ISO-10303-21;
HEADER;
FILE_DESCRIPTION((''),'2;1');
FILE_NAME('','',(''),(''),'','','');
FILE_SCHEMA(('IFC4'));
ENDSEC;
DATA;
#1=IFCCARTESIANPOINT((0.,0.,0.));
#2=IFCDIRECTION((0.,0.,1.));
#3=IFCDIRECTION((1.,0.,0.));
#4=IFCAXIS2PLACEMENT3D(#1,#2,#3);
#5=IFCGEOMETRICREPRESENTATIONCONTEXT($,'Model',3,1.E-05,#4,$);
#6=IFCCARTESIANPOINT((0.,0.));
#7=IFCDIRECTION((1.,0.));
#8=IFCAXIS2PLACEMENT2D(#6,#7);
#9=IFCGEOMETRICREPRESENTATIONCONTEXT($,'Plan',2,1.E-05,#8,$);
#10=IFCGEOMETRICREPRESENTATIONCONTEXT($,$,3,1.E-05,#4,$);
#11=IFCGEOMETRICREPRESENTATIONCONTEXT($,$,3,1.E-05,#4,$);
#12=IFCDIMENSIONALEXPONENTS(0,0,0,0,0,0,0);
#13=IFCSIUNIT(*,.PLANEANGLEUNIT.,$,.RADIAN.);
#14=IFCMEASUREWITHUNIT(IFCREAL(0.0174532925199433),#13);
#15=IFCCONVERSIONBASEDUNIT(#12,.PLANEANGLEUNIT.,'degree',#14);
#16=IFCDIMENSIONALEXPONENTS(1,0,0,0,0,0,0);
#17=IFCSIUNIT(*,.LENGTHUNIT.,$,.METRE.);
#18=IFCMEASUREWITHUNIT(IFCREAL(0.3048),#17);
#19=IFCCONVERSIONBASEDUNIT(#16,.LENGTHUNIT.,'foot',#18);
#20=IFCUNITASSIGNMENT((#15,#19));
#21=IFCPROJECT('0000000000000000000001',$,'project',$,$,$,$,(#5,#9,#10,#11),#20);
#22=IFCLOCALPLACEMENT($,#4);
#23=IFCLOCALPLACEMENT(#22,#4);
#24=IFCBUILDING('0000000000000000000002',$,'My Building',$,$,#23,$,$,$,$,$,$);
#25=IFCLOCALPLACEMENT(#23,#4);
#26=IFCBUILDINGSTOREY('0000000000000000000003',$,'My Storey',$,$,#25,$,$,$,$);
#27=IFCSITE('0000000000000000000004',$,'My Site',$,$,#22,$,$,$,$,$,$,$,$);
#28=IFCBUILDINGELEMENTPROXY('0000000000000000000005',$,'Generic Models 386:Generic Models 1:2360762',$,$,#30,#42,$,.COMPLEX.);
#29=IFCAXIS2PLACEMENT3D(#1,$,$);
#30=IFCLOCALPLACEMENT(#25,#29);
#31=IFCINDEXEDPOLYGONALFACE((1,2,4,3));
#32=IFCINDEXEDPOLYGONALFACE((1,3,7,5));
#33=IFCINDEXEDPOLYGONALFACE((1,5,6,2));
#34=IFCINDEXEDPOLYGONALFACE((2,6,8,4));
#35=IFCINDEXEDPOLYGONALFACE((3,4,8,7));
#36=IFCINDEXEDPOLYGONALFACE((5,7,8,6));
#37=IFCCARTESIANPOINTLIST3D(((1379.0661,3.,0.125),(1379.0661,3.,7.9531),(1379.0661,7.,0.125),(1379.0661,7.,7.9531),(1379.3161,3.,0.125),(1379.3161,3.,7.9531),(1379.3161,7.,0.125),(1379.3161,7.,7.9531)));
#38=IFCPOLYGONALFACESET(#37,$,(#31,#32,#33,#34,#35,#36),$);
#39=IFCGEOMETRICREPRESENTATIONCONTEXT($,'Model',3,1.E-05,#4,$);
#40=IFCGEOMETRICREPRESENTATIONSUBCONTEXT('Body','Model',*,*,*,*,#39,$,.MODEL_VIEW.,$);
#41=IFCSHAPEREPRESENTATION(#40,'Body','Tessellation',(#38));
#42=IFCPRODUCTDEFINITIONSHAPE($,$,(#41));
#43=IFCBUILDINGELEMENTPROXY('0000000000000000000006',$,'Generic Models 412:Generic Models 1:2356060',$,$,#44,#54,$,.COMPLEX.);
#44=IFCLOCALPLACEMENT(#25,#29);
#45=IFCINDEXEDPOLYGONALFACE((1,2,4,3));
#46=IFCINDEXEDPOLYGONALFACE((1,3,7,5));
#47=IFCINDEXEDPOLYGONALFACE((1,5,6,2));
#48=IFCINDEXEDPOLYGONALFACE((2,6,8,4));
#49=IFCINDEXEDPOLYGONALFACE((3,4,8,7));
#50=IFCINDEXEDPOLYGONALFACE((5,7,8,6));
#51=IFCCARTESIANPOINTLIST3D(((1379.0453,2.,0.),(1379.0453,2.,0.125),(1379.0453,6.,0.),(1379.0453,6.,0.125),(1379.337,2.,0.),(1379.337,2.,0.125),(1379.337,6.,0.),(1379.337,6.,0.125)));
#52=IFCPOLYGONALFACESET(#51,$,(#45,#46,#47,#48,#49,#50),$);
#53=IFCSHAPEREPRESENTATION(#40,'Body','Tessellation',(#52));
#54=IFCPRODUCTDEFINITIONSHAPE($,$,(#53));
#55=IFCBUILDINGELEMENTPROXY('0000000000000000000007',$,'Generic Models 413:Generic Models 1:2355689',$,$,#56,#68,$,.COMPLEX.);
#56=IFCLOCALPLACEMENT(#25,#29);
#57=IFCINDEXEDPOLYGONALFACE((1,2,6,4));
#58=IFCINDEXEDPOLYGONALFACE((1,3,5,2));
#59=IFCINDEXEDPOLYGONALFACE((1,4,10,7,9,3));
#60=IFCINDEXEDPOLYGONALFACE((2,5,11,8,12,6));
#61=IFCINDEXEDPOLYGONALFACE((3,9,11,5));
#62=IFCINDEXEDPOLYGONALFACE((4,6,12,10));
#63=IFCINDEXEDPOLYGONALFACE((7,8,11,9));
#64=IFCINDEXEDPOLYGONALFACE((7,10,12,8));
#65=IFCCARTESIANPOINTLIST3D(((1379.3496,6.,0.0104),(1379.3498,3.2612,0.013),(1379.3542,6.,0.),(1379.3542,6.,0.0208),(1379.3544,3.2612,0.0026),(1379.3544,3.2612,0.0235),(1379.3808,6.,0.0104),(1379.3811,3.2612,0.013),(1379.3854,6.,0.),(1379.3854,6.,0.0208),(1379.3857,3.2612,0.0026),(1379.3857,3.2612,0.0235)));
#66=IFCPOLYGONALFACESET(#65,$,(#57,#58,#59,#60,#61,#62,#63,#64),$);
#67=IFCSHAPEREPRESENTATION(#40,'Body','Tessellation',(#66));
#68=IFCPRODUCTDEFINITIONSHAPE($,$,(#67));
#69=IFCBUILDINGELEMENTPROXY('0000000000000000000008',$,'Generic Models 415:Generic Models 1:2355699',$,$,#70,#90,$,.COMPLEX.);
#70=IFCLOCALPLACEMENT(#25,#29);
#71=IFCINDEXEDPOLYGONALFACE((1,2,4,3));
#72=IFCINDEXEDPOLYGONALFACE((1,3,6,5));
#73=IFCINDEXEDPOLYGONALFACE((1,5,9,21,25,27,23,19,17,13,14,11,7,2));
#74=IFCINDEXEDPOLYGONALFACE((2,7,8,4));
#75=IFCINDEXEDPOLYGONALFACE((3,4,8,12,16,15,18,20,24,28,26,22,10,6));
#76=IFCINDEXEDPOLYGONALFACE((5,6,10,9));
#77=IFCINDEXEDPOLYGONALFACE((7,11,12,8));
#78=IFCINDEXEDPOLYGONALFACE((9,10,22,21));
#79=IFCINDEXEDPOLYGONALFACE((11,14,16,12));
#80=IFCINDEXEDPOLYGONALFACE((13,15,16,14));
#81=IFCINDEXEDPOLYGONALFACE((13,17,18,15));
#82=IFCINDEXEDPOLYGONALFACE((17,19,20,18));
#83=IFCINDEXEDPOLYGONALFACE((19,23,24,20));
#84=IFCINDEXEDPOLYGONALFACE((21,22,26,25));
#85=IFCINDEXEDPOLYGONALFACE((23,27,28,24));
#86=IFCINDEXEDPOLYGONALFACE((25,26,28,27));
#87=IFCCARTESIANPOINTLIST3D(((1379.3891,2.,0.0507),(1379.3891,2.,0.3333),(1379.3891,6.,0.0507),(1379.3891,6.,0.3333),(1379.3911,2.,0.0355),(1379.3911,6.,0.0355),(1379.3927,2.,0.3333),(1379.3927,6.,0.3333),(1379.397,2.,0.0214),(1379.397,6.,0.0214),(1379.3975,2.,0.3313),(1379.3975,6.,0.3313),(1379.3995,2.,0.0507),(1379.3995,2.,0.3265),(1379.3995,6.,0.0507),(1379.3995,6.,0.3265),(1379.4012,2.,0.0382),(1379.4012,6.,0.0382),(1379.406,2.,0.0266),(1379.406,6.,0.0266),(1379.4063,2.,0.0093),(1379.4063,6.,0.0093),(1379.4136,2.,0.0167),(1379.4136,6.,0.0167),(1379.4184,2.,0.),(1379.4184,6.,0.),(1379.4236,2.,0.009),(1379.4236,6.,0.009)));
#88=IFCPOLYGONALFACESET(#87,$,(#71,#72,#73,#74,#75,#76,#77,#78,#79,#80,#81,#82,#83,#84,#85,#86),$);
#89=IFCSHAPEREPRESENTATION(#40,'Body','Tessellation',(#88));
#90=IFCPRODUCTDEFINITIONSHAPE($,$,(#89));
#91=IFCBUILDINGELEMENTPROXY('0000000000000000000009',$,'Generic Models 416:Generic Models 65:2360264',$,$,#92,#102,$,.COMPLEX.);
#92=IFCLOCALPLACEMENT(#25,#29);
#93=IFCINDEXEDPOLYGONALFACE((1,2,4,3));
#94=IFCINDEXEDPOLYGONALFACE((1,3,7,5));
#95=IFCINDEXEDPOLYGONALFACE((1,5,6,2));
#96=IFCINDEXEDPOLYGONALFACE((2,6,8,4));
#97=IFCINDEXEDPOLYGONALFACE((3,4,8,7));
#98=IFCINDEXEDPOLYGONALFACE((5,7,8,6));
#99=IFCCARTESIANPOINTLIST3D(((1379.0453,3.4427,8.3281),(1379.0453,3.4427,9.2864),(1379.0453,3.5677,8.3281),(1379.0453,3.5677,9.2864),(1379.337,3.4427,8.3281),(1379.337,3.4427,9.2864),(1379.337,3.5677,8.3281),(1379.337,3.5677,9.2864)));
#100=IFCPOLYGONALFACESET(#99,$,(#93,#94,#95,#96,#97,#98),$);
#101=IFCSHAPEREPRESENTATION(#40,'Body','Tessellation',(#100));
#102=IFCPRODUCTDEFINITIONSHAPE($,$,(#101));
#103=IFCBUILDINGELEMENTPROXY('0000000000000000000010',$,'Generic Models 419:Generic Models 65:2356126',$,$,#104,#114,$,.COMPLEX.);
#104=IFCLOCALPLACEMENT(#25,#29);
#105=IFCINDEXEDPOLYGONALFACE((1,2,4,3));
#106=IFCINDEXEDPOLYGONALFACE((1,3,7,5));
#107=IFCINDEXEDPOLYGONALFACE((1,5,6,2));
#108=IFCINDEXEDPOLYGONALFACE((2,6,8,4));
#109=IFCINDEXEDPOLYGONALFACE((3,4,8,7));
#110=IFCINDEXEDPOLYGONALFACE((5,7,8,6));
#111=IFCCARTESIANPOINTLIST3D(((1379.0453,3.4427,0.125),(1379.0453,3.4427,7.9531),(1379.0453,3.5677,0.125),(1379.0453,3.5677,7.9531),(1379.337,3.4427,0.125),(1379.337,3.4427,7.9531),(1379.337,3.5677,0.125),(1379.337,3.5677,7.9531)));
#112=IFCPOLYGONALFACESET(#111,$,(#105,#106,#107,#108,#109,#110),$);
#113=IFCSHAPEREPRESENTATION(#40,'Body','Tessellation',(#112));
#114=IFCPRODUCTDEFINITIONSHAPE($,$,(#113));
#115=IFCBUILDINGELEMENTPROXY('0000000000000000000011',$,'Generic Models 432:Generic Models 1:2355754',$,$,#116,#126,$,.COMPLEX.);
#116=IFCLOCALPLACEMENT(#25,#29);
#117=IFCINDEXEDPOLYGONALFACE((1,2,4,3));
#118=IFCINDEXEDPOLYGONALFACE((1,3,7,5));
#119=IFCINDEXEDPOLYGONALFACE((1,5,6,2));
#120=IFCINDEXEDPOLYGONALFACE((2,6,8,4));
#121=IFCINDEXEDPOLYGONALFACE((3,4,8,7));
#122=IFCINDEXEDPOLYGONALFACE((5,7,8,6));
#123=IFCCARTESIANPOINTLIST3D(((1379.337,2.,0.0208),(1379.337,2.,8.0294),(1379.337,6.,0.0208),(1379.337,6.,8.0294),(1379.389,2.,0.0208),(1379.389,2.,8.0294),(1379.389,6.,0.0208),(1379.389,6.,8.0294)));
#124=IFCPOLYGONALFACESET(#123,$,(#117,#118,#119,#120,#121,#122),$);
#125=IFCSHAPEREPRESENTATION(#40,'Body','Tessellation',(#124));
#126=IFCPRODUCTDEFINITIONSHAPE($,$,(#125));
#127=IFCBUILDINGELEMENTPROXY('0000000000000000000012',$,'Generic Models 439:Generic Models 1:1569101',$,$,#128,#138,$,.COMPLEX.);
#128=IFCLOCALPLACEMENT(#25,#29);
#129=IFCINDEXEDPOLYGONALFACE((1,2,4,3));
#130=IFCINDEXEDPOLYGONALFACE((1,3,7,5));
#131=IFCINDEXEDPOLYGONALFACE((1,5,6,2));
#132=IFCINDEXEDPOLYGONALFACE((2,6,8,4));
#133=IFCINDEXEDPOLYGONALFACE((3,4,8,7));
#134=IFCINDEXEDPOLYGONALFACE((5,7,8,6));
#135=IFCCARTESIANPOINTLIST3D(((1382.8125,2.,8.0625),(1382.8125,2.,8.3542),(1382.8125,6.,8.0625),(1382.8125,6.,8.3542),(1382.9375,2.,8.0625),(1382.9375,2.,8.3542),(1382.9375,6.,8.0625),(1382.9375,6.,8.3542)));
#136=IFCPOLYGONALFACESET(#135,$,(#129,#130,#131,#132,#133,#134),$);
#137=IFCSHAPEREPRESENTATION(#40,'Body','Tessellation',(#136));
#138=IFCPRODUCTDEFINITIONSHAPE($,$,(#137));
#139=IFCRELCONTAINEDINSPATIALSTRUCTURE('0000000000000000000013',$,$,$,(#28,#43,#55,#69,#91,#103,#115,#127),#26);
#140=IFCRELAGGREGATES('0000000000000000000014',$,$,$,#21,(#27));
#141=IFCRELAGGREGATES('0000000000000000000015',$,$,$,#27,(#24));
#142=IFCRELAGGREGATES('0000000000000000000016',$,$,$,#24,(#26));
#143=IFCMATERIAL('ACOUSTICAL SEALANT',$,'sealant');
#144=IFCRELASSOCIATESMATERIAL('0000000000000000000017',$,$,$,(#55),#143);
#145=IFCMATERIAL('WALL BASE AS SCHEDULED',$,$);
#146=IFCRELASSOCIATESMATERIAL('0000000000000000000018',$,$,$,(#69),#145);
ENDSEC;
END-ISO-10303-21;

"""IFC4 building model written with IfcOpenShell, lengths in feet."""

from ifc_helpers import new_model, entity, si_unit, converted_unit, frame, origin_with_axes, origin_2d_with_axis, place, context, subcontext, project, spatial, polyline, outline, extrude, material, element, save


model = new_model("IFC4")

# Units and contexts
model_context_1 = context("Model", 3, precision=1e-05, world=origin_with_axes())
plan_context = context("Plan", 2, precision=1e-05, world=origin_2d_with_axis())
model_context_2 = context("Model", 3, precision=1e-05, world=origin_with_axes())
context_of_model_1 = context(None, 3, precision=1e-05, world=origin_with_axes())
context_of_model_2 = context(None, 3, precision=1e-05, world=origin_with_axes())
body_context = subcontext(model_context_2, "Body", "Model", "MODEL_VIEW")
ifc_project = project(units=[converted_unit("PLANEANGLEUNIT", "degree", entity("IfcReal", 0.0174532925199433), si_unit("PLANEANGLEUNIT", "RADIAN"), dimensions=[0, 0, 0, 0, 0, 0, 0]), converted_unit("LENGTHUNIT", "foot", entity("IfcReal", 0.3048), si_unit("LENGTHUNIT", "METRE"), dimensions=[1, 0, 0, 0, 0, 0, 0])], contexts=[model_context_1, plan_context, context_of_model_1, context_of_model_2])

# Site, building, storey
site_placement = place(None, origin_with_axes())
site = spatial("IfcSite", under=ifc_project, at=site_placement, Name="My Site")
building_placement = place(site_placement, origin_with_axes())
building = spatial("IfcBuilding", under=site, at=building_placement, Name="My Building")
storey_placement = place(building_placement, origin_with_axes())
storey = spatial("IfcBuildingStorey", under=building, at=storey_placement, Name="My Storey")

# Building element proxies
ifc_material_1 = material(Name="WALL BASE AS SCHEDULED")
ifc_material_2 = material(Name="ACOUSTICAL SEALANT", Category="sealant")
proxy_1_placement = place(storey_placement, frame((1379.0661, 3.0, 0.125), z_axis=(0.0, 0.0, 1.0), x_axis=(0.0, 1.0, 0.0)))
element("IfcBuildingElementProxy", 1, at=proxy_1_placement, inside=storey, Name="Generic Models 386:Generic Models 1:2360762", PredefinedType="COMPLEX", context=body_context, shape_type="SweptSolid", body=[
    extrude(outline(polyline([(-2.0, -0.125), (2.0, -0.125), (2.0, 0.125), (-2.0, 0.125), (-2.0, -0.125)])), frame((2.0, -0.125, 0.0), z_axis=(0.0, 0.0, -1.0), x_axis=(-1.0, 0.0, 0.0)), (0.0, 0.0, -1.0), 7.8281),
])
proxy_2_placement = place(storey_placement, frame((1379.0453, 6.0, 0.0), z_axis=(0.0, -1.0, 0.0), x_axis=(0.0, 0.0, 1.0)))
element("IfcBuildingElementProxy", 2, at=proxy_2_placement, inside=storey, Name="Generic Models 412:Generic Models 1:2356060", PredefinedType="COMPLEX", context=body_context, shape_type="SweptSolid", body=[
    extrude(outline(polyline([(-0.0625, -0.1458), (0.0625, -0.1458), (0.0625, 0.1458), (-0.0625, 0.1458), (-0.0625, -0.1458)])), frame((0.0625, -0.1458, 0.0), z_axis=(0.0, 0.0, -1.0), x_axis=(1.0, 0.0, 0.0)), (0.0, 0.0, -1.0), 4.0),
])
proxy_3_placement = place(storey_placement, frame((1379.3497, 6.0, 0.0), z_axis=(0.0, -1.0, 0.0), x_axis=(0.0, 0.0, 1.0)))
element("IfcBuildingElementProxy", 3, at=proxy_3_placement, inside=storey, material=ifc_material_2, Name="Generic Models 413:Generic Models 1:2355689", PredefinedType="COMPLEX", context=body_context, shape_type="SweptSolid", body=[
    extrude(outline(polyline([(0.0201, 0.0), (0.0107, 0.0065), (0.0093, 0.0178), (-0.0175, 0.0016), (-0.016, -0.0097), (-0.0066, -0.0162), (0.0201, 0.0)])), frame((0.0104, -0.0186, 0.0), z_axis=(0.0, 0.0, -1.0), x_axis=(0.51911, -0.854707, 0.0)), (0.000574, -0.000772, -1.0), 2.7388),
])
proxy_4_placement = place(storey_placement, frame((1379.3891, 6.0, 0.0), z_axis=(0.0, -1.0, 0.0), x_axis=(0.0, 0.0, 1.0)))
element("IfcBuildingElementProxy", 4, at=proxy_4_placement, inside=storey, material=ifc_material_1, Name="Generic Models 415:Generic Models 1:2355699", PredefinedType="COMPLEX", context=body_context, shape_type="SweptSolid", body=[
    extrude(outline(polyline([(-0.2134, 0.0022), (0.0624, 0.0022), (0.0748, 0.0006), (0.0864, -0.0042), (0.0964, -0.0119), (0.104, -0.0218), (0.113, -0.0166), (0.1037, -0.0045), (0.0916, 0.0048), (0.0775, 0.0106), (0.0624, 0.0126), (-0.2203, 0.0126), (-0.2203, 0.0091), (-0.2183, 0.0042), (-0.2134, 0.0022)])), frame((0.113, -0.0126, 0.0), z_axis=(0.0, 0.0, -1.0), x_axis=(-1.0, 0.0, 0.0)), (0.0, 0.0, -1.0), 4.0),
])
proxy_5_placement = place(storey_placement, frame((1379.0453, 3.4427, 8.3281), z_axis=(0.0, 0.0, 1.0), x_axis=(1.0, 0.0, 0.0)))
element("IfcBuildingElementProxy", 5, at=proxy_5_placement, inside=storey, Name="Generic Models 416:Generic Models 65:2360264", PredefinedType="COMPLEX", context=body_context, shape_type="SweptSolid", body=[
    extrude(outline(polyline([(-0.1458, -0.0625), (0.1458, -0.0625), (0.1458, 0.0625), (-0.1458, 0.0625), (-0.1458, -0.0625)])), frame((0.1458, 0.0625, 0.0), z_axis=(0.0, 0.0, -1.0), x_axis=(-1.0, 0.0, 0.0)), (0.0, 0.0, -1.0), 0.9583),
])
proxy_6_placement = place(storey_placement, frame((1379.0453, 3.4427, 0.125), z_axis=(0.0, 0.0, 1.0), x_axis=(1.0, 0.0, 0.0)))
element("IfcBuildingElementProxy", 6, at=proxy_6_placement, inside=storey, Name="Generic Models 419:Generic Models 65:2356126", PredefinedType="COMPLEX", context=body_context, shape_type="SweptSolid", body=[
    extrude(outline(polyline([(-0.1458, -0.0625), (0.1458, -0.0625), (0.1458, 0.0625), (-0.1458, 0.0625), (-0.1458, -0.0625)])), frame((0.1458, 0.0625, 0.0), z_axis=(0.0, 0.0, -1.0), x_axis=(-1.0, 0.0, 0.0)), (0.0, 0.0, -1.0), 7.8281),
])
proxy_7_placement = place(storey_placement, frame((1379.337, 6.0, 0.0208), z_axis=(0.0, -1.0, 0.0), x_axis=(0.0, 0.0, 1.0)))
element("IfcBuildingElementProxy", 7, at=proxy_7_placement, inside=storey, Name="Generic Models 432:Generic Models 1:2355754", PredefinedType="COMPLEX", context=body_context, shape_type="SweptSolid", body=[
    extrude(outline(polyline([(-4.0043, -0.026), (4.0043, -0.026), (4.0043, 0.026), (-4.0043, 0.026), (-4.0043, -0.026)])), frame((4.0043, -0.026, 0.0), z_axis=(0.0, 0.0, -1.0), x_axis=(1.0, 0.0, 0.0)), (0.0, 0.0, -1.0), 4.0),
])
proxy_8_placement = place(storey_placement, frame((1382.8125, 6.0, 8.0625), z_axis=(0.0, -1.0, 0.0), x_axis=(0.0, 0.0, 1.0)))
element("IfcBuildingElementProxy", 8, at=proxy_8_placement, inside=storey, Name="Generic Models 439:Generic Models 1:1569101", PredefinedType="COMPLEX", context=body_context, shape_type="SweptSolid", body=[
    extrude(outline(polyline([(-0.0625, -0.1458), (0.0625, -0.1458), (0.0625, 0.1458), (-0.0625, 0.1458), (-0.0625, -0.1458)])), frame((0.1458, -0.0625, 0.0), z_axis=(0.0, 0.0, -1.0), x_axis=(0.0, 1.0, 0.0)), (0.0, 0.0, -1.0), 4.0),
])

save(model, "model.ifc")
